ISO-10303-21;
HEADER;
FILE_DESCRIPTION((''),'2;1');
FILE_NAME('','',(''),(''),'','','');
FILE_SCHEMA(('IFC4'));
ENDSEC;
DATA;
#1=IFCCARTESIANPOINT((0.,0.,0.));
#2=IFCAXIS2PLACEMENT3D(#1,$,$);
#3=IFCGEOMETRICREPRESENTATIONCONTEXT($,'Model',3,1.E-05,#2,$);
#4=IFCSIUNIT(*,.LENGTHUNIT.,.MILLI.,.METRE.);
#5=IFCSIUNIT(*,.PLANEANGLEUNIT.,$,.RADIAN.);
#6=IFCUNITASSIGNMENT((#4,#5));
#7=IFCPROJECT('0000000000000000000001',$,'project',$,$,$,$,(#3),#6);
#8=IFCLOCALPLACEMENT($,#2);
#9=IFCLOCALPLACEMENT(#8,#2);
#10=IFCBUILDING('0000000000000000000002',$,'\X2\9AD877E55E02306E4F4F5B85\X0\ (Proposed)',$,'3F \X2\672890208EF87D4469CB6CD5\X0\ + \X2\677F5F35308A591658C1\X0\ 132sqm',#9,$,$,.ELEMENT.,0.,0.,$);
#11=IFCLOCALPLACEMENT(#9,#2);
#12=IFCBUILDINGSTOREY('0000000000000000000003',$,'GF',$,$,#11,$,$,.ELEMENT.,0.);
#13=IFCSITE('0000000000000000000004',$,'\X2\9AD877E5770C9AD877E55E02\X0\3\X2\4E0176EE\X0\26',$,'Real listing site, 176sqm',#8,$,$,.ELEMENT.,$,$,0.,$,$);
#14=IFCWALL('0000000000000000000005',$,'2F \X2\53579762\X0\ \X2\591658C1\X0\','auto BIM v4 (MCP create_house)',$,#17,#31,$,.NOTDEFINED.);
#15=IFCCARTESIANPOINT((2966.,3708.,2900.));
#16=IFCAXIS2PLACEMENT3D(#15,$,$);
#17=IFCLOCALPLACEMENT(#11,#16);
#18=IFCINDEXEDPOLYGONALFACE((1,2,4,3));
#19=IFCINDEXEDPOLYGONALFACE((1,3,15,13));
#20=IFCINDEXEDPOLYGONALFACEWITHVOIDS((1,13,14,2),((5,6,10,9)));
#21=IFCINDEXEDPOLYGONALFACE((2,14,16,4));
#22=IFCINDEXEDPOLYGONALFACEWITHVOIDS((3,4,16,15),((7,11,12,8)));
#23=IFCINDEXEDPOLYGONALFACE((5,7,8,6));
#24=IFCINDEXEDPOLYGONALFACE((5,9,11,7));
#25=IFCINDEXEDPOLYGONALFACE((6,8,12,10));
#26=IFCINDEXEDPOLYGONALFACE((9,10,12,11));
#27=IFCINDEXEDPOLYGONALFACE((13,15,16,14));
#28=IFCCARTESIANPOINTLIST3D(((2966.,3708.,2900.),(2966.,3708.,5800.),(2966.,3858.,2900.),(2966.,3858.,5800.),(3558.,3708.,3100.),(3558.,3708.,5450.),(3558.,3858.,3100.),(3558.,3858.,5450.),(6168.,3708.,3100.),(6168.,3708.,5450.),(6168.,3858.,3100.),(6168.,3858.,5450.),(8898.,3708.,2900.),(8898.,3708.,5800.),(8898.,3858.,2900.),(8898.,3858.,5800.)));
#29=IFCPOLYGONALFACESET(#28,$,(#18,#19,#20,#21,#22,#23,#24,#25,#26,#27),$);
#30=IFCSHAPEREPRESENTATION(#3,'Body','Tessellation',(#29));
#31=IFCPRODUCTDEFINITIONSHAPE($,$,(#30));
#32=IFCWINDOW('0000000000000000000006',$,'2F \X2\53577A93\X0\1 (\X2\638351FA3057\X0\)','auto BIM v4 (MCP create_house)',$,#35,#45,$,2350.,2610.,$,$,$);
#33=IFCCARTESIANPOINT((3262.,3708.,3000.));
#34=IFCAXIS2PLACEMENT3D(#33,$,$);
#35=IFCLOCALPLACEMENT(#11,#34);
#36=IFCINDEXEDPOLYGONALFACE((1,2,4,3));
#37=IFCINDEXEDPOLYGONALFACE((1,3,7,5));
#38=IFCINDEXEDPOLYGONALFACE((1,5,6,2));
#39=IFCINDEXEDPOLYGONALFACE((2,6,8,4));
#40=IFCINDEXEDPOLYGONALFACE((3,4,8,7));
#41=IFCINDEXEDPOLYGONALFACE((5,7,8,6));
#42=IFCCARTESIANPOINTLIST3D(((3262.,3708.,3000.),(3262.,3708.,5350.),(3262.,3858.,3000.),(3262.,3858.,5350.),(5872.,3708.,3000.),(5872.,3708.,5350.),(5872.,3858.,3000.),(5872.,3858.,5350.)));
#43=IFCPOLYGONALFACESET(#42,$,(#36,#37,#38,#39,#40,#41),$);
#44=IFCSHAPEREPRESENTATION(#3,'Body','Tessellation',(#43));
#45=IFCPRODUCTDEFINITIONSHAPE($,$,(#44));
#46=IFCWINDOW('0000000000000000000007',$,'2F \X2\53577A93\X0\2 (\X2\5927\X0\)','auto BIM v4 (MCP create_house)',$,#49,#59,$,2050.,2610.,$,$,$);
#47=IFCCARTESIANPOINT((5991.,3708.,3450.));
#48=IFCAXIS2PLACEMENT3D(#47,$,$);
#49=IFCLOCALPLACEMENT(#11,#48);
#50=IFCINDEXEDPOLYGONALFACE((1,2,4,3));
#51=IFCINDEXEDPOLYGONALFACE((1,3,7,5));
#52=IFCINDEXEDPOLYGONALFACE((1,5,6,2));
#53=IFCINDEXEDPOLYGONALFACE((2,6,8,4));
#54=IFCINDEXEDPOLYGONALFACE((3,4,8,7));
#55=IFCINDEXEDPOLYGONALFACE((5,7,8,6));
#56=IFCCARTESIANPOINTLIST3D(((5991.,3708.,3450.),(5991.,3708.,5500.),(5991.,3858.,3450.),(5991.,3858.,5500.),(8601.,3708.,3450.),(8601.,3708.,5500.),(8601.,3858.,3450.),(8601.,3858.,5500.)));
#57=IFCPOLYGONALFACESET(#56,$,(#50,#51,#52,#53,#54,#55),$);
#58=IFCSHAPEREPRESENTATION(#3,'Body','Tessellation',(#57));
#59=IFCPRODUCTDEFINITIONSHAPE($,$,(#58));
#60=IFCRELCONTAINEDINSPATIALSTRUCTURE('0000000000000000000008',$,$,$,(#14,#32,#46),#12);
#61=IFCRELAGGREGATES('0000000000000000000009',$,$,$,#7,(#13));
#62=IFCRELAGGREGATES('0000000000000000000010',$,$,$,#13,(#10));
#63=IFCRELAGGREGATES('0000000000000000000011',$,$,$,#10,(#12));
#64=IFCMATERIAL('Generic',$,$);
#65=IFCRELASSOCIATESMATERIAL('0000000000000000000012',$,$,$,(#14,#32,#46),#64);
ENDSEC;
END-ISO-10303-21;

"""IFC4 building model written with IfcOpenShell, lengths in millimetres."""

from ifc_helpers import new_model, si_unit, frame, frame_2d, origin, place, context, project, spatial, rectangle, extrude, material, element, fill, save


model = new_model("IFC4")

# Units and contexts
model_context = context("Model", 3, precision=1e-05, world=origin())
ifc_project = project(units=[si_unit("LENGTHUNIT", "METRE", prefix="MILLI"), si_unit("PLANEANGLEUNIT", "RADIAN")], contexts=[model_context])

# Site, building, storey
site_placement = place(None, origin())
site = spatial("IfcSite", under=ifc_project, at=site_placement, Name="高知県高知市3丁目26", ObjectType="Real listing site, 176sqm", CompositionType="ELEMENT", RefElevation=0.0)
building_placement = place(site_placement, origin())
building = spatial("IfcBuilding", under=site, at=building_placement, Name="高知市の住宅 (Proposed)", ObjectType="3F 木造軸組構法 + 板張り外壁 132sqm", CompositionType="ELEMENT", ElevationOfRefHeight=0.0, ElevationOfTerrain=0.0)
storey_placement = place(building_placement, origin())
storey = spatial("IfcBuildingStorey", under=building, at=storey_placement, Name="GF", CompositionType="ELEMENT", Elevation=0.0)

# Shared definitions
ifc_material = material(Name="Generic")

# Wall, openings, windows
wall_1_placement = place(storey_placement, frame((2966.0, 3708.0, 2900.0)))
wall_1 = element("IfcWall", 1, at=wall_1_placement, inside=storey, material=ifc_material, Name="2F 南面 外壁", Description="auto BIM v4 (MCP create_house)", PredefinedType="NOTDEFINED", context=model_context, shape_type="SweptSolid", body=[
    extrude(rectangle(XDim=5932.0, YDim=150.0, at=frame_2d((2966.0, 75.0))), frame((2966.0, 3708.0, 2900.0)), (0.0, 0.0, 1.0), 2900.0),
])
opening_1_placement = place(storey_placement, frame((3262.0, 3708.0, 3000.0)))
opening_1 = element("IfcOpeningElement", 2, at=opening_1_placement, cuts=wall_1, PredefinedType="NOTDEFINED", context=model_context, shape_type="SweptSolid", body=[
    extrude(rectangle(XDim=2610.0, YDim=150.0, at=frame_2d((1305.0, 75.0))), frame((3262.0, 3708.0, 3000.0)), (0.0, 0.0, 1.0), 2350.0),
])
opening_2_placement = place(storey_placement, frame((5991.0, 3708.0, 3450.0)))
opening_2 = element("IfcOpeningElement", 3, at=opening_2_placement, cuts=wall_1, PredefinedType="NOTDEFINED", context=model_context, shape_type="SweptSolid", body=[
    extrude(rectangle(XDim=2610.0, YDim=150.0, at=frame_2d((1305.0, 75.0))), frame((5991.0, 3708.0, 3450.0)), (0.0, 0.0, 1.0), 2050.0),
])
window_1_placement = place(storey_placement, frame((3262.0, 3708.0, 3000.0)))
window_1 = element("IfcWindow", 4, at=window_1_placement, inside=storey, material=ifc_material, Name="2F 南窓1 (掃出し)", Description="auto BIM v4 (MCP create_house)", OverallHeight=2350.0, OverallWidth=2610.0, context=model_context, shape_type="SweptSolid", body=[
    extrude(rectangle(XDim=2610.0, YDim=150.0, at=frame_2d((1305.0, 75.0))), frame((3262.0, 3708.0, 3000.0)), (0.0, 0.0, 1.0), 2350.0),
])
fill(opening_1, window_1)
window_2_placement = place(storey_placement, frame((5991.0, 3708.0, 3450.0)))
window_2 = element("IfcWindow", 5, at=window_2_placement, inside=storey, material=ifc_material, Name="2F 南窓2 (大)", Description="auto BIM v4 (MCP create_house)", OverallHeight=2050.0, OverallWidth=2610.0, context=model_context, shape_type="SweptSolid", body=[
    extrude(rectangle(XDim=2610.0, YDim=150.0, at=frame_2d((1305.0, 75.0))), frame((5991.0, 3708.0, 3450.0)), (0.0, 0.0, 1.0), 2050.0),
])
fill(opening_2, window_2)

save(model, "model.ifc")
